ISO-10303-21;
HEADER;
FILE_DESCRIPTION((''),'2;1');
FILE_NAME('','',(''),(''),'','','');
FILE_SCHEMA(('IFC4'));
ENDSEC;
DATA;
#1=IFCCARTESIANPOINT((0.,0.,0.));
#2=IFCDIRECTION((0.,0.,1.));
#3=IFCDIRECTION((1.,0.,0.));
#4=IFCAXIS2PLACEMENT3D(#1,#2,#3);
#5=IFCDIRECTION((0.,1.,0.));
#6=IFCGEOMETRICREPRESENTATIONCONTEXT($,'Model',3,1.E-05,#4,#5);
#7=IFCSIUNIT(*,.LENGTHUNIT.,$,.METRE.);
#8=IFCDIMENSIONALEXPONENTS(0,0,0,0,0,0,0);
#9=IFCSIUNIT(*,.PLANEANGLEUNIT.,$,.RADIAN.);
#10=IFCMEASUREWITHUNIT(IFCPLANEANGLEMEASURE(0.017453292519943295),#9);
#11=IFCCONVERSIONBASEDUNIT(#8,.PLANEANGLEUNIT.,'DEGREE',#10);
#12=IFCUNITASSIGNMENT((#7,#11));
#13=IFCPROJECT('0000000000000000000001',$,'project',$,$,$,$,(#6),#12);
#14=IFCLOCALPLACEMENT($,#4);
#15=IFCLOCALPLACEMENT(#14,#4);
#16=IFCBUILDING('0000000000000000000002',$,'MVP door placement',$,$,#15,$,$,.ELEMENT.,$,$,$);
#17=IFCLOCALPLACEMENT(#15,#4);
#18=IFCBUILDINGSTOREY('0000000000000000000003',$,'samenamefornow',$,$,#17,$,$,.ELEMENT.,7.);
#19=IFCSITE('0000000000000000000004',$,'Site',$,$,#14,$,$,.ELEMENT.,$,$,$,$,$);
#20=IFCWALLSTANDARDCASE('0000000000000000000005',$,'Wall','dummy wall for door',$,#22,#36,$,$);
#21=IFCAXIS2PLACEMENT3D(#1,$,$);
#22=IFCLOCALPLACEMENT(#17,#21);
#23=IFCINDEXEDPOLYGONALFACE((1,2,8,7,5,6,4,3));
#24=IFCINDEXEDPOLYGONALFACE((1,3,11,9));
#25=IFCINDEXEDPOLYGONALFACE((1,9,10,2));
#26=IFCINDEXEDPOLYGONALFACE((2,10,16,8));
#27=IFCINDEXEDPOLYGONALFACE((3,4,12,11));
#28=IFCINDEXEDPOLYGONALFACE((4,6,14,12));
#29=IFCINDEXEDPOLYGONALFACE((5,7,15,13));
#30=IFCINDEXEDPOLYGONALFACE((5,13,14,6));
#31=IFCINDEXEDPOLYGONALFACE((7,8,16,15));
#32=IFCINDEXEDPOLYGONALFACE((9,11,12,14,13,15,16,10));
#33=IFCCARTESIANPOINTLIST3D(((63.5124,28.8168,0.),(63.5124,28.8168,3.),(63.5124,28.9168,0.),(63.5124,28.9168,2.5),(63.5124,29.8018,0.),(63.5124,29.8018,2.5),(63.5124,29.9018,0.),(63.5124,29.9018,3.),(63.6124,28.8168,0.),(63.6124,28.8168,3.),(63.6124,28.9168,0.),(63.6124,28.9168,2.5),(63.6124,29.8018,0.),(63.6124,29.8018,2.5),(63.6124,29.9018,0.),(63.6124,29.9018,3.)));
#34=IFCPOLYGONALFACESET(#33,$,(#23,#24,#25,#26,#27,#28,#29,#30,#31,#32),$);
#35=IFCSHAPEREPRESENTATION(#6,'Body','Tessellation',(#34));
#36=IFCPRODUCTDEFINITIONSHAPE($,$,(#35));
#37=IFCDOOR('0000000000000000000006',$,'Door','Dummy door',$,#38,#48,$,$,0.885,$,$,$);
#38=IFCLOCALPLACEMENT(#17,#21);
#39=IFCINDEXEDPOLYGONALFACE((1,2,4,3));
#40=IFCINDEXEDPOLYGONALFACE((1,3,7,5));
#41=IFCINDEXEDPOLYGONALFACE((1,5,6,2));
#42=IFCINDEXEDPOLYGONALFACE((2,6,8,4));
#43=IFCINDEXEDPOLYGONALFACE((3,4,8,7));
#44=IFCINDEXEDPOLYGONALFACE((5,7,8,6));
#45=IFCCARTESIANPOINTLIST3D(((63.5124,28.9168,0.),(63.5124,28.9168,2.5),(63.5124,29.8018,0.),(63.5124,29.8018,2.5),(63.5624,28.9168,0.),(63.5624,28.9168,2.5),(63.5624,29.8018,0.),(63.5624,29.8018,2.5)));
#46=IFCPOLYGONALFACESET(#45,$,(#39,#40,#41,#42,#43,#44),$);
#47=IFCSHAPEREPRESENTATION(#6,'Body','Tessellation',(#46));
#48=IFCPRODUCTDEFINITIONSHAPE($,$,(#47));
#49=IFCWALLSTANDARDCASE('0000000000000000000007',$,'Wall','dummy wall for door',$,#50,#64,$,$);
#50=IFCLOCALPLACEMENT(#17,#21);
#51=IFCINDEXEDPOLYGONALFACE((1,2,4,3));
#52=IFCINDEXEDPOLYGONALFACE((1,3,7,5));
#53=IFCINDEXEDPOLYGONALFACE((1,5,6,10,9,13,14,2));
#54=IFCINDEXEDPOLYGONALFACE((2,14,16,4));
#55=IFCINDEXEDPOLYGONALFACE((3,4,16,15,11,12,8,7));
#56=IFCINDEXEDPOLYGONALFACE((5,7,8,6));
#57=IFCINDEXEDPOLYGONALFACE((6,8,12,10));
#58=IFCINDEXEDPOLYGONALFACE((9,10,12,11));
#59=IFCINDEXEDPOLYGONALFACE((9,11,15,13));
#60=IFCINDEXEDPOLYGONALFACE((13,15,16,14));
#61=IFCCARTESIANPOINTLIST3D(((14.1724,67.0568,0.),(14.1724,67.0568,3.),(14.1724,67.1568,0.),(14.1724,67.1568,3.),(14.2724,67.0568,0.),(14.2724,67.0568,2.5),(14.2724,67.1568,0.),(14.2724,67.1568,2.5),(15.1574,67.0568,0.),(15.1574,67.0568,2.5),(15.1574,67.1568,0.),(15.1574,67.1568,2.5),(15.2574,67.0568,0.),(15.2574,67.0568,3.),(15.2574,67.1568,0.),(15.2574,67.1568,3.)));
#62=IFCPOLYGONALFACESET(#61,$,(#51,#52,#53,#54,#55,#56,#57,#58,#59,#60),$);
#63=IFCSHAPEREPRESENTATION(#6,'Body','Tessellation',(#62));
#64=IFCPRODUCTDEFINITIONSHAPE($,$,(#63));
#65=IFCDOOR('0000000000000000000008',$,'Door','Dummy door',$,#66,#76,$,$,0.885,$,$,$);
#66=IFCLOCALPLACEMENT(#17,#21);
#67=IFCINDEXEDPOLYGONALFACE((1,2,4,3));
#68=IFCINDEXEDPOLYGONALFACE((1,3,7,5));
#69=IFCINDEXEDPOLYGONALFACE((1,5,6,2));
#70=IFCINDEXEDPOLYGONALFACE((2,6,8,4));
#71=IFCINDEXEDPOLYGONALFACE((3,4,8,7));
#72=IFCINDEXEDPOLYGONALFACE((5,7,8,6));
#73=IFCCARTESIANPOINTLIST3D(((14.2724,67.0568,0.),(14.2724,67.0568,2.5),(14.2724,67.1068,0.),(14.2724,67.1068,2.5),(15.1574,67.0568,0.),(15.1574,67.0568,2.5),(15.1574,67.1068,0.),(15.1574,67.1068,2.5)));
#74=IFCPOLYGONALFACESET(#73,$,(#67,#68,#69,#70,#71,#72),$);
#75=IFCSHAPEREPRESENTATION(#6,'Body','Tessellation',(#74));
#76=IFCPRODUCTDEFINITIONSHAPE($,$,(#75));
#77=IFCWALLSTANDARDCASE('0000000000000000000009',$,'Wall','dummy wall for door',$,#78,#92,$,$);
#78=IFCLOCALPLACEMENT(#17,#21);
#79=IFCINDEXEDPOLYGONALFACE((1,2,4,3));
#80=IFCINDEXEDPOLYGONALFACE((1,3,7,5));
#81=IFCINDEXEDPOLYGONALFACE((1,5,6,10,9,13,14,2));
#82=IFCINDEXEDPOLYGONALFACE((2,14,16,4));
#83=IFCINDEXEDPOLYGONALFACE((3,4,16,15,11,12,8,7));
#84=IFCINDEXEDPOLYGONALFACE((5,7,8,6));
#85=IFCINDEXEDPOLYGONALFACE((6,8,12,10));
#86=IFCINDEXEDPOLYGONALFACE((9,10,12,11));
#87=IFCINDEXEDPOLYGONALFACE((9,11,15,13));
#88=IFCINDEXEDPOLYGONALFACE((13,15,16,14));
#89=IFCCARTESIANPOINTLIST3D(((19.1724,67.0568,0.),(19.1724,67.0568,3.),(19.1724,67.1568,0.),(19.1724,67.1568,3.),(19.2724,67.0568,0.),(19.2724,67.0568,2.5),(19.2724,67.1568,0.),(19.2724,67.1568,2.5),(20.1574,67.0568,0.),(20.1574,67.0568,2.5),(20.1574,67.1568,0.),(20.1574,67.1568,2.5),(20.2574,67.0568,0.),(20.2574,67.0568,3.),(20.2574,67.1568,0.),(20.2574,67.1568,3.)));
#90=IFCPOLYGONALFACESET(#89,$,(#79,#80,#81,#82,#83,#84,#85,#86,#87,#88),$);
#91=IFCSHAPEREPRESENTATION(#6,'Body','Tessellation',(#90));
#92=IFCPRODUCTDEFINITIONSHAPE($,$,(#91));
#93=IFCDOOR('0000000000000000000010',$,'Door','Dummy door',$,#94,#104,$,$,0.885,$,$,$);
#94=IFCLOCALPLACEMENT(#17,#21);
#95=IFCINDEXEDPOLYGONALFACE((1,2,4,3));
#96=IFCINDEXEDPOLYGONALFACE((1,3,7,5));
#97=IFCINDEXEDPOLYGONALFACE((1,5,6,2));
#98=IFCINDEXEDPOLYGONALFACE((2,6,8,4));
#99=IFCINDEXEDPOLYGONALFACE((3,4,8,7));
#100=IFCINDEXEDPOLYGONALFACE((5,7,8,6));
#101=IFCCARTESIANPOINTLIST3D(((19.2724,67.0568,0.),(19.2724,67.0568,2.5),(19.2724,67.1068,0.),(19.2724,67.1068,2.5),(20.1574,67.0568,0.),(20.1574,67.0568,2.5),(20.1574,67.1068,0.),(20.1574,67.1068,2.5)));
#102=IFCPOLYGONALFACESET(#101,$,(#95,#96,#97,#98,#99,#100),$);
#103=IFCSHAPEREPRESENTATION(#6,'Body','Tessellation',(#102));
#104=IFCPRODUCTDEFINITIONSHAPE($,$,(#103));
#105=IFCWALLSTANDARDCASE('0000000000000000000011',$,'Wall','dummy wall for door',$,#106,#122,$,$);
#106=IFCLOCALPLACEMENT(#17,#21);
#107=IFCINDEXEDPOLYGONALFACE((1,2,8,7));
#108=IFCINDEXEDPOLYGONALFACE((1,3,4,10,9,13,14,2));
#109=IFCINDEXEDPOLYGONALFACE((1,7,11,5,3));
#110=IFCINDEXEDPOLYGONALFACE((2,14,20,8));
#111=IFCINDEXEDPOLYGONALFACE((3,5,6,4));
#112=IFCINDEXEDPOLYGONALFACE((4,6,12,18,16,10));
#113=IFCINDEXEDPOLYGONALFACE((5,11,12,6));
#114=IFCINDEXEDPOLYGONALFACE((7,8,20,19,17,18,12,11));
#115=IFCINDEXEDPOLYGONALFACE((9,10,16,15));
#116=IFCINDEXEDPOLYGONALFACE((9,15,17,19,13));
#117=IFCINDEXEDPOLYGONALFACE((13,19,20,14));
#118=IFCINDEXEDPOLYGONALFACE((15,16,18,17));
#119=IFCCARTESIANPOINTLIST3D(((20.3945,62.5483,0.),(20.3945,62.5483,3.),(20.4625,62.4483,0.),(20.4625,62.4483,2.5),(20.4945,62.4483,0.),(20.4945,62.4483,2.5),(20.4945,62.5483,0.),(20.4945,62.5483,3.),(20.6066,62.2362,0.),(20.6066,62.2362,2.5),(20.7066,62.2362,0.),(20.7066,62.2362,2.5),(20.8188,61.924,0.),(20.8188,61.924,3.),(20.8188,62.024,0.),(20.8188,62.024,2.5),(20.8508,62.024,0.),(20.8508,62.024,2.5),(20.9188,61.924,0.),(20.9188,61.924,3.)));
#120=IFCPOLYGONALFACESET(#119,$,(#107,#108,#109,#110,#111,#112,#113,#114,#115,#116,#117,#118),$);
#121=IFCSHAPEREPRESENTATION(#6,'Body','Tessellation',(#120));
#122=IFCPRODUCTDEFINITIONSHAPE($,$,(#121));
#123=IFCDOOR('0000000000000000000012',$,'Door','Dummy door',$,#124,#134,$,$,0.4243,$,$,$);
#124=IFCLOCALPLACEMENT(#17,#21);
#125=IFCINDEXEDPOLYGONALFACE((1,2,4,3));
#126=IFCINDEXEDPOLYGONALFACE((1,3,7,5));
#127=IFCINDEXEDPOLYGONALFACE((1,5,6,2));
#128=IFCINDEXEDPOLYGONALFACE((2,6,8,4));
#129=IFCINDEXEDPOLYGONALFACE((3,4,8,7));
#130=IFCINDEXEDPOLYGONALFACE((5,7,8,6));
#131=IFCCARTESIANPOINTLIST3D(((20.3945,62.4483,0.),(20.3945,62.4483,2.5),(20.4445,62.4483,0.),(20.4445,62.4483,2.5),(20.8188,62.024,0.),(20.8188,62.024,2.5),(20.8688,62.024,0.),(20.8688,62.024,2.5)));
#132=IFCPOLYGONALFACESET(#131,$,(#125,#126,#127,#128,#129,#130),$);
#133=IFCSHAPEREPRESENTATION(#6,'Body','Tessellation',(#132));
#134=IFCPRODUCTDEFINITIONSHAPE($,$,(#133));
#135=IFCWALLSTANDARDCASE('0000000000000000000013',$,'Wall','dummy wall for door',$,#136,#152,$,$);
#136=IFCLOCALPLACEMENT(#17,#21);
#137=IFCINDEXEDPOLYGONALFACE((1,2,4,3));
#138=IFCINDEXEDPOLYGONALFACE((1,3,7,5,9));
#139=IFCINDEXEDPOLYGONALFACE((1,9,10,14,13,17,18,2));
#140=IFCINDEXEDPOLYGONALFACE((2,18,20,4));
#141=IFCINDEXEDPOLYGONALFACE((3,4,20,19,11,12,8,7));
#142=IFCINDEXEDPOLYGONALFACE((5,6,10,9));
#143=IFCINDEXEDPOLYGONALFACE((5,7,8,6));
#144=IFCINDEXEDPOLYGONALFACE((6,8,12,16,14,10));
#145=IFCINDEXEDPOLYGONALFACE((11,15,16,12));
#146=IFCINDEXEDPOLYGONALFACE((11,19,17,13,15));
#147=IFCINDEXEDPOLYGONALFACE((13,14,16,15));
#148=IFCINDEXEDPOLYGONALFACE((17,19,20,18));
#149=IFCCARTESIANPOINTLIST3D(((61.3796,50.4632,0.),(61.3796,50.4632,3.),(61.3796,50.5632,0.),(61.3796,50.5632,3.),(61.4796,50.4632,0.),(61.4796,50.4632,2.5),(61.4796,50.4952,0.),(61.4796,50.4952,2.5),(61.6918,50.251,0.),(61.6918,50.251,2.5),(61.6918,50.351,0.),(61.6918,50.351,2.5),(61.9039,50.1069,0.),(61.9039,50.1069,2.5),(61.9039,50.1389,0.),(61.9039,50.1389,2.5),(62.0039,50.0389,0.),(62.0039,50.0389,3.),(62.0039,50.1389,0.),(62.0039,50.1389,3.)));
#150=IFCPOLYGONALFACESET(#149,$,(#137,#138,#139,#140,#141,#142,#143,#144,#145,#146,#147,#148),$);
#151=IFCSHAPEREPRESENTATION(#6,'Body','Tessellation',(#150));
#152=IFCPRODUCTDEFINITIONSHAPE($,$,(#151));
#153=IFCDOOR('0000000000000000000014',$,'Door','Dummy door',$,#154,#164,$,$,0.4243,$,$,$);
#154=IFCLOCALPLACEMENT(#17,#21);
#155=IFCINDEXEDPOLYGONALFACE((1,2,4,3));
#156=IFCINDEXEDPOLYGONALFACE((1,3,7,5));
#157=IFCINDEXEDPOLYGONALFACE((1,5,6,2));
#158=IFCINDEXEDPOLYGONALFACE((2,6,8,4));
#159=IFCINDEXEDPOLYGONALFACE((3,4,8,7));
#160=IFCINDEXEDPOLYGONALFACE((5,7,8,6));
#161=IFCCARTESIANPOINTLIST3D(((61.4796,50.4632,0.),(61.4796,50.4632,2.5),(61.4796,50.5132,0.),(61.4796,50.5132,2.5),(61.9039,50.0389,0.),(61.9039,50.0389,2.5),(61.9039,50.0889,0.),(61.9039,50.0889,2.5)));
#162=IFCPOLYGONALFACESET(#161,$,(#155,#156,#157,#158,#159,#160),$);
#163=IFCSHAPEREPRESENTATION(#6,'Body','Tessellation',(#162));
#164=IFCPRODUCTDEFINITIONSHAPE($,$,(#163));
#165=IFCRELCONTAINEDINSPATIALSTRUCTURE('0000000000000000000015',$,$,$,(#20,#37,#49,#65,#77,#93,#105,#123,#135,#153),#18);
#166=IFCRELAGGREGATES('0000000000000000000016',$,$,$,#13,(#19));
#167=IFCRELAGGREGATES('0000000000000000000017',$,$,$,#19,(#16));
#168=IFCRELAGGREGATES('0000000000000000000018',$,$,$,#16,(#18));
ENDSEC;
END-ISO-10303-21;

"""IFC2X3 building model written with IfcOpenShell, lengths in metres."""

from ifc_helpers import new_model, entity, si_unit, converted_unit, direction, origin_with_axes, place, context, project, spatial, polyline, outline, extrude, element, fill, save


model = new_model("IFC2X3")

# Units and contexts
model_context = context("Model", 3, precision=1e-05, world=origin_with_axes(), true_north=direction((0.0, 1.0, 0.0)))
ifc_project = project(units=[si_unit("LENGTHUNIT", "METRE"), converted_unit("PLANEANGLEUNIT", "DEGREE", entity("IfcPlaneAngleMeasure", 0.017453292519943295), si_unit("PLANEANGLEUNIT", "RADIAN"), dimensions=[0, 0, 0, 0, 0, 0, 0])], contexts=[model_context])

# Site, building, storey
site_placement = place(None, origin_with_axes())
site = spatial("IfcSite", under=ifc_project, at=site_placement, Name="Site", CompositionType="ELEMENT")
building_placement = place(site_placement, origin_with_axes())
building = spatial("IfcBuilding", under=site, at=building_placement, Name="MVP door placement", CompositionType="ELEMENT")
storey_placement = place(building_placement, origin_with_axes())
storey = spatial("IfcBuildingStorey", under=building, at=storey_placement, Name="samenamefornow", CompositionType="ELEMENT", Elevation=7.0)

# Walls, openings, doors
wall_1_placement = place(storey_placement, origin_with_axes())
wall_1 = element("IfcWallStandardCase", 1, at=wall_1_placement, inside=storey, Name="Wall", Description="dummy wall for door", context=model_context, shape_type="SweptSolid", body=[
    extrude(outline(polyline([(63.5124, 29.9018, 0.0), (63.5124, 28.8168, 0.0), (63.6124, 28.8168, 0.0), (63.6124, 29.9018, 0.0), (63.5124, 29.9018, 0.0)])), origin_with_axes(), (0.0, 0.0, 1.0), 3.0),
])
opening_1_placement = place(wall_1_placement, origin_with_axes())
opening_1 = element("IfcOpeningElement", 2, at=opening_1_placement, cuts=wall_1, context=model_context, shape_type="SweptSolid", body=[
    extrude(outline(polyline([(63.5124, 29.8018, 0.0), (63.5124, 28.9168, 0.0), (63.6124, 28.9168, 0.0), (63.6124, 29.8018, 0.0), (63.5124, 29.8018, 0.0)])), origin_with_axes(), (0.0, 0.0, 1.0), 2.5),
])
door_1_placement = place(opening_1_placement, origin_with_axes())
door_1 = element("IfcDoor", 3, at=door_1_placement, inside=storey, Name="Door", Description="Dummy door", OverallWidth=0.885, context=model_context, shape_type="SweptSolid", body=[
    extrude(outline(polyline([(63.5124, 29.8018, 0.0), (63.5124, 28.9168, 0.0), (63.5624, 28.9168, 0.0), (63.5624, 29.8018, 0.0), (63.5124, 29.8018, 0.0)])), origin_with_axes(), (0.0, 0.0, 1.0), 2.5),
])
fill(opening_1, door_1)
wall_2_placement = place(storey_placement, origin_with_axes())
wall_2 = element("IfcWallStandardCase", 4, at=wall_2_placement, inside=storey, Name="Wall", Description="dummy wall for door", context=model_context, shape_type="SweptSolid", body=[
    extrude(outline(polyline([(15.2574, 67.0568, 0.0), (14.1724, 67.0568, 0.0), (14.1724, 67.1568, 0.0), (15.2574, 67.1568, 0.0), (15.2574, 67.0568, 0.0)])), origin_with_axes(), (0.0, 0.0, 1.0), 3.0),
])
opening_2_placement = place(wall_2_placement, origin_with_axes())
opening_2 = element("IfcOpeningElement", 5, at=opening_2_placement, cuts=wall_2, context=model_context, shape_type="SweptSolid", body=[
    extrude(outline(polyline([(15.1574, 67.0568, 0.0), (14.2724, 67.0568, 0.0), (14.2724, 67.1568, 0.0), (15.1574, 67.1568, 0.0), (15.1574, 67.0568, 0.0)])), origin_with_axes(), (0.0, 0.0, 1.0), 2.5),
])
door_2_placement = place(opening_2_placement, origin_with_axes())
door_2 = element("IfcDoor", 6, at=door_2_placement, inside=storey, Name="Door", Description="Dummy door", OverallWidth=0.885, context=model_context, shape_type="SweptSolid", body=[
    extrude(outline(polyline([(15.1574, 67.0568, 0.0), (14.2724, 67.0568, 0.0), (14.2724, 67.1068, 0.0), (15.1574, 67.1068, 0.0), (15.1574, 67.0568, 0.0)])), origin_with_axes(), (0.0, 0.0, 1.0), 2.5),
])
fill(opening_2, door_2)
wall_3_placement = place(storey_placement, origin_with_axes())
wall_3 = element("IfcWallStandardCase", 7, at=wall_3_placement, inside=storey, Name="Wall", Description="dummy wall for door", context=model_context, shape_type="SweptSolid", body=[
    extrude(outline(polyline([(20.2574, 67.0568, 0.0), (19.1724, 67.0568, 0.0), (19.1724, 67.1568, 0.0), (20.2574, 67.1568, 0.0), (20.2574, 67.0568, 0.0)])), origin_with_axes(), (0.0, 0.0, 1.0), 3.0),
])
opening_3_placement = place(wall_3_placement, origin_with_axes())
opening_3 = element("IfcOpeningElement", 8, at=opening_3_placement, cuts=wall_3, context=model_context, shape_type="SweptSolid", body=[
    extrude(outline(polyline([(20.1574, 67.0568, 0.0), (19.2724, 67.0568, 0.0), (19.2724, 67.1568, 0.0), (20.1574, 67.1568, 0.0), (20.1574, 67.0568, 0.0)])), origin_with_axes(), (0.0, 0.0, 1.0), 2.5),
])
door_3_placement = place(opening_3_placement, origin_with_axes())
door_3 = element("IfcDoor", 9, at=door_3_placement, inside=storey, Name="Door", Description="Dummy door", OverallWidth=0.885, context=model_context, shape_type="SweptSolid", body=[
    extrude(outline(polyline([(20.1574, 67.0568, 0.0), (19.2724, 67.0568, 0.0), (19.2724, 67.1068, 0.0), (20.1574, 67.1068, 0.0), (20.1574, 67.0568, 0.0)])), origin_with_axes(), (0.0, 0.0, 1.0), 2.5),
])
fill(opening_3, door_3)
wall_4_placement = place(storey_placement, origin_with_axes())
wall_4 = element("IfcWallStandardCase", 10, at=wall_4_placement, inside=storey, Name="Wall", Description="dummy wall for door", context=model_context, shape_type="SweptSolid", body=[
    extrude(outline(polyline([(20.8188, 61.924, 0.0), (20.3945, 62.5483, 0.0), (20.4945, 62.5483, 0.0), (20.9188, 61.924, 0.0), (20.8188, 61.924, 0.0)])), origin_with_axes(), (0.0, 0.0, 1.0), 3.0),
])
opening_4_placement = place(wall_4_placement, origin_with_axes())
opening_4 = element("IfcOpeningElement", 11, at=opening_4_placement, cuts=wall_4, context=model_context, shape_type="SweptSolid", body=[
    extrude(outline(polyline([(20.8188, 62.024, 0.0), (20.3945, 62.4483, 0.0), (20.4945, 62.4483, 0.0), (20.9188, 62.024, 0.0), (20.8188, 62.024, 0.0)])), origin_with_axes(), (0.0, 0.0, 1.0), 2.5),
])
door_4_placement = place(opening_4_placement, origin_with_axes())
door_4 = element("IfcDoor", 12, at=door_4_placement, inside=storey, Name="Door", Description="Dummy door", OverallWidth=0.4243, context=model_context, shape_type="SweptSolid", body=[
    extrude(outline(polyline([(20.8188, 62.024, 0.0), (20.3945, 62.4483, 0.0), (20.4445, 62.4483, 0.0), (20.8688, 62.024, 0.0), (20.8188, 62.024, 0.0)])), origin_with_axes(), (0.0, 0.0, 1.0), 2.5),
])
fill(opening_4, door_4)
wall_5_placement = place(storey_placement, origin_with_axes())
wall_5 = element("IfcWallStandardCase", 13, at=wall_5_placement, inside=storey, Name="Wall", Description="dummy wall for door", context=model_context, shape_type="SweptSolid", body=[
    extrude(outline(polyline([(61.3796, 50.4632, 0.0), (62.0039, 50.0389, 0.0), (62.0039, 50.1389, 0.0), (61.3796, 50.5632, 0.0), (61.3796, 50.4632, 0.0)])), origin_with_axes(), (0.0, 0.0, 1.0), 3.0),
])
opening_5_placement = place(wall_5_placement, origin_with_axes())
opening_5 = element("IfcOpeningElement", 14, at=opening_5_placement, cuts=wall_5, context=model_context, shape_type="SweptSolid", body=[
    extrude(outline(polyline([(61.4796, 50.4632, 0.0), (61.9039, 50.0389, 0.0), (61.9039, 50.1389, 0.0), (61.4796, 50.5632, 0.0), (61.4796, 50.4632, 0.0)])), origin_with_axes(), (0.0, 0.0, 1.0), 2.5),
])
door_5_placement = place(opening_5_placement, origin_with_axes())
door_5 = element("IfcDoor", 15, at=door_5_placement, inside=storey, Name="Door", Description="Dummy door", OverallWidth=0.4243, context=model_context, shape_type="SweptSolid", body=[
    extrude(outline(polyline([(61.4796, 50.4632, 0.0), (61.9039, 50.0389, 0.0), (61.9039, 50.0889, 0.0), (61.4796, 50.5132, 0.0), (61.4796, 50.4632, 0.0)])), origin_with_axes(), (0.0, 0.0, 1.0), 2.5),
])
fill(opening_5, door_5)

save(model, "model.ifc")
